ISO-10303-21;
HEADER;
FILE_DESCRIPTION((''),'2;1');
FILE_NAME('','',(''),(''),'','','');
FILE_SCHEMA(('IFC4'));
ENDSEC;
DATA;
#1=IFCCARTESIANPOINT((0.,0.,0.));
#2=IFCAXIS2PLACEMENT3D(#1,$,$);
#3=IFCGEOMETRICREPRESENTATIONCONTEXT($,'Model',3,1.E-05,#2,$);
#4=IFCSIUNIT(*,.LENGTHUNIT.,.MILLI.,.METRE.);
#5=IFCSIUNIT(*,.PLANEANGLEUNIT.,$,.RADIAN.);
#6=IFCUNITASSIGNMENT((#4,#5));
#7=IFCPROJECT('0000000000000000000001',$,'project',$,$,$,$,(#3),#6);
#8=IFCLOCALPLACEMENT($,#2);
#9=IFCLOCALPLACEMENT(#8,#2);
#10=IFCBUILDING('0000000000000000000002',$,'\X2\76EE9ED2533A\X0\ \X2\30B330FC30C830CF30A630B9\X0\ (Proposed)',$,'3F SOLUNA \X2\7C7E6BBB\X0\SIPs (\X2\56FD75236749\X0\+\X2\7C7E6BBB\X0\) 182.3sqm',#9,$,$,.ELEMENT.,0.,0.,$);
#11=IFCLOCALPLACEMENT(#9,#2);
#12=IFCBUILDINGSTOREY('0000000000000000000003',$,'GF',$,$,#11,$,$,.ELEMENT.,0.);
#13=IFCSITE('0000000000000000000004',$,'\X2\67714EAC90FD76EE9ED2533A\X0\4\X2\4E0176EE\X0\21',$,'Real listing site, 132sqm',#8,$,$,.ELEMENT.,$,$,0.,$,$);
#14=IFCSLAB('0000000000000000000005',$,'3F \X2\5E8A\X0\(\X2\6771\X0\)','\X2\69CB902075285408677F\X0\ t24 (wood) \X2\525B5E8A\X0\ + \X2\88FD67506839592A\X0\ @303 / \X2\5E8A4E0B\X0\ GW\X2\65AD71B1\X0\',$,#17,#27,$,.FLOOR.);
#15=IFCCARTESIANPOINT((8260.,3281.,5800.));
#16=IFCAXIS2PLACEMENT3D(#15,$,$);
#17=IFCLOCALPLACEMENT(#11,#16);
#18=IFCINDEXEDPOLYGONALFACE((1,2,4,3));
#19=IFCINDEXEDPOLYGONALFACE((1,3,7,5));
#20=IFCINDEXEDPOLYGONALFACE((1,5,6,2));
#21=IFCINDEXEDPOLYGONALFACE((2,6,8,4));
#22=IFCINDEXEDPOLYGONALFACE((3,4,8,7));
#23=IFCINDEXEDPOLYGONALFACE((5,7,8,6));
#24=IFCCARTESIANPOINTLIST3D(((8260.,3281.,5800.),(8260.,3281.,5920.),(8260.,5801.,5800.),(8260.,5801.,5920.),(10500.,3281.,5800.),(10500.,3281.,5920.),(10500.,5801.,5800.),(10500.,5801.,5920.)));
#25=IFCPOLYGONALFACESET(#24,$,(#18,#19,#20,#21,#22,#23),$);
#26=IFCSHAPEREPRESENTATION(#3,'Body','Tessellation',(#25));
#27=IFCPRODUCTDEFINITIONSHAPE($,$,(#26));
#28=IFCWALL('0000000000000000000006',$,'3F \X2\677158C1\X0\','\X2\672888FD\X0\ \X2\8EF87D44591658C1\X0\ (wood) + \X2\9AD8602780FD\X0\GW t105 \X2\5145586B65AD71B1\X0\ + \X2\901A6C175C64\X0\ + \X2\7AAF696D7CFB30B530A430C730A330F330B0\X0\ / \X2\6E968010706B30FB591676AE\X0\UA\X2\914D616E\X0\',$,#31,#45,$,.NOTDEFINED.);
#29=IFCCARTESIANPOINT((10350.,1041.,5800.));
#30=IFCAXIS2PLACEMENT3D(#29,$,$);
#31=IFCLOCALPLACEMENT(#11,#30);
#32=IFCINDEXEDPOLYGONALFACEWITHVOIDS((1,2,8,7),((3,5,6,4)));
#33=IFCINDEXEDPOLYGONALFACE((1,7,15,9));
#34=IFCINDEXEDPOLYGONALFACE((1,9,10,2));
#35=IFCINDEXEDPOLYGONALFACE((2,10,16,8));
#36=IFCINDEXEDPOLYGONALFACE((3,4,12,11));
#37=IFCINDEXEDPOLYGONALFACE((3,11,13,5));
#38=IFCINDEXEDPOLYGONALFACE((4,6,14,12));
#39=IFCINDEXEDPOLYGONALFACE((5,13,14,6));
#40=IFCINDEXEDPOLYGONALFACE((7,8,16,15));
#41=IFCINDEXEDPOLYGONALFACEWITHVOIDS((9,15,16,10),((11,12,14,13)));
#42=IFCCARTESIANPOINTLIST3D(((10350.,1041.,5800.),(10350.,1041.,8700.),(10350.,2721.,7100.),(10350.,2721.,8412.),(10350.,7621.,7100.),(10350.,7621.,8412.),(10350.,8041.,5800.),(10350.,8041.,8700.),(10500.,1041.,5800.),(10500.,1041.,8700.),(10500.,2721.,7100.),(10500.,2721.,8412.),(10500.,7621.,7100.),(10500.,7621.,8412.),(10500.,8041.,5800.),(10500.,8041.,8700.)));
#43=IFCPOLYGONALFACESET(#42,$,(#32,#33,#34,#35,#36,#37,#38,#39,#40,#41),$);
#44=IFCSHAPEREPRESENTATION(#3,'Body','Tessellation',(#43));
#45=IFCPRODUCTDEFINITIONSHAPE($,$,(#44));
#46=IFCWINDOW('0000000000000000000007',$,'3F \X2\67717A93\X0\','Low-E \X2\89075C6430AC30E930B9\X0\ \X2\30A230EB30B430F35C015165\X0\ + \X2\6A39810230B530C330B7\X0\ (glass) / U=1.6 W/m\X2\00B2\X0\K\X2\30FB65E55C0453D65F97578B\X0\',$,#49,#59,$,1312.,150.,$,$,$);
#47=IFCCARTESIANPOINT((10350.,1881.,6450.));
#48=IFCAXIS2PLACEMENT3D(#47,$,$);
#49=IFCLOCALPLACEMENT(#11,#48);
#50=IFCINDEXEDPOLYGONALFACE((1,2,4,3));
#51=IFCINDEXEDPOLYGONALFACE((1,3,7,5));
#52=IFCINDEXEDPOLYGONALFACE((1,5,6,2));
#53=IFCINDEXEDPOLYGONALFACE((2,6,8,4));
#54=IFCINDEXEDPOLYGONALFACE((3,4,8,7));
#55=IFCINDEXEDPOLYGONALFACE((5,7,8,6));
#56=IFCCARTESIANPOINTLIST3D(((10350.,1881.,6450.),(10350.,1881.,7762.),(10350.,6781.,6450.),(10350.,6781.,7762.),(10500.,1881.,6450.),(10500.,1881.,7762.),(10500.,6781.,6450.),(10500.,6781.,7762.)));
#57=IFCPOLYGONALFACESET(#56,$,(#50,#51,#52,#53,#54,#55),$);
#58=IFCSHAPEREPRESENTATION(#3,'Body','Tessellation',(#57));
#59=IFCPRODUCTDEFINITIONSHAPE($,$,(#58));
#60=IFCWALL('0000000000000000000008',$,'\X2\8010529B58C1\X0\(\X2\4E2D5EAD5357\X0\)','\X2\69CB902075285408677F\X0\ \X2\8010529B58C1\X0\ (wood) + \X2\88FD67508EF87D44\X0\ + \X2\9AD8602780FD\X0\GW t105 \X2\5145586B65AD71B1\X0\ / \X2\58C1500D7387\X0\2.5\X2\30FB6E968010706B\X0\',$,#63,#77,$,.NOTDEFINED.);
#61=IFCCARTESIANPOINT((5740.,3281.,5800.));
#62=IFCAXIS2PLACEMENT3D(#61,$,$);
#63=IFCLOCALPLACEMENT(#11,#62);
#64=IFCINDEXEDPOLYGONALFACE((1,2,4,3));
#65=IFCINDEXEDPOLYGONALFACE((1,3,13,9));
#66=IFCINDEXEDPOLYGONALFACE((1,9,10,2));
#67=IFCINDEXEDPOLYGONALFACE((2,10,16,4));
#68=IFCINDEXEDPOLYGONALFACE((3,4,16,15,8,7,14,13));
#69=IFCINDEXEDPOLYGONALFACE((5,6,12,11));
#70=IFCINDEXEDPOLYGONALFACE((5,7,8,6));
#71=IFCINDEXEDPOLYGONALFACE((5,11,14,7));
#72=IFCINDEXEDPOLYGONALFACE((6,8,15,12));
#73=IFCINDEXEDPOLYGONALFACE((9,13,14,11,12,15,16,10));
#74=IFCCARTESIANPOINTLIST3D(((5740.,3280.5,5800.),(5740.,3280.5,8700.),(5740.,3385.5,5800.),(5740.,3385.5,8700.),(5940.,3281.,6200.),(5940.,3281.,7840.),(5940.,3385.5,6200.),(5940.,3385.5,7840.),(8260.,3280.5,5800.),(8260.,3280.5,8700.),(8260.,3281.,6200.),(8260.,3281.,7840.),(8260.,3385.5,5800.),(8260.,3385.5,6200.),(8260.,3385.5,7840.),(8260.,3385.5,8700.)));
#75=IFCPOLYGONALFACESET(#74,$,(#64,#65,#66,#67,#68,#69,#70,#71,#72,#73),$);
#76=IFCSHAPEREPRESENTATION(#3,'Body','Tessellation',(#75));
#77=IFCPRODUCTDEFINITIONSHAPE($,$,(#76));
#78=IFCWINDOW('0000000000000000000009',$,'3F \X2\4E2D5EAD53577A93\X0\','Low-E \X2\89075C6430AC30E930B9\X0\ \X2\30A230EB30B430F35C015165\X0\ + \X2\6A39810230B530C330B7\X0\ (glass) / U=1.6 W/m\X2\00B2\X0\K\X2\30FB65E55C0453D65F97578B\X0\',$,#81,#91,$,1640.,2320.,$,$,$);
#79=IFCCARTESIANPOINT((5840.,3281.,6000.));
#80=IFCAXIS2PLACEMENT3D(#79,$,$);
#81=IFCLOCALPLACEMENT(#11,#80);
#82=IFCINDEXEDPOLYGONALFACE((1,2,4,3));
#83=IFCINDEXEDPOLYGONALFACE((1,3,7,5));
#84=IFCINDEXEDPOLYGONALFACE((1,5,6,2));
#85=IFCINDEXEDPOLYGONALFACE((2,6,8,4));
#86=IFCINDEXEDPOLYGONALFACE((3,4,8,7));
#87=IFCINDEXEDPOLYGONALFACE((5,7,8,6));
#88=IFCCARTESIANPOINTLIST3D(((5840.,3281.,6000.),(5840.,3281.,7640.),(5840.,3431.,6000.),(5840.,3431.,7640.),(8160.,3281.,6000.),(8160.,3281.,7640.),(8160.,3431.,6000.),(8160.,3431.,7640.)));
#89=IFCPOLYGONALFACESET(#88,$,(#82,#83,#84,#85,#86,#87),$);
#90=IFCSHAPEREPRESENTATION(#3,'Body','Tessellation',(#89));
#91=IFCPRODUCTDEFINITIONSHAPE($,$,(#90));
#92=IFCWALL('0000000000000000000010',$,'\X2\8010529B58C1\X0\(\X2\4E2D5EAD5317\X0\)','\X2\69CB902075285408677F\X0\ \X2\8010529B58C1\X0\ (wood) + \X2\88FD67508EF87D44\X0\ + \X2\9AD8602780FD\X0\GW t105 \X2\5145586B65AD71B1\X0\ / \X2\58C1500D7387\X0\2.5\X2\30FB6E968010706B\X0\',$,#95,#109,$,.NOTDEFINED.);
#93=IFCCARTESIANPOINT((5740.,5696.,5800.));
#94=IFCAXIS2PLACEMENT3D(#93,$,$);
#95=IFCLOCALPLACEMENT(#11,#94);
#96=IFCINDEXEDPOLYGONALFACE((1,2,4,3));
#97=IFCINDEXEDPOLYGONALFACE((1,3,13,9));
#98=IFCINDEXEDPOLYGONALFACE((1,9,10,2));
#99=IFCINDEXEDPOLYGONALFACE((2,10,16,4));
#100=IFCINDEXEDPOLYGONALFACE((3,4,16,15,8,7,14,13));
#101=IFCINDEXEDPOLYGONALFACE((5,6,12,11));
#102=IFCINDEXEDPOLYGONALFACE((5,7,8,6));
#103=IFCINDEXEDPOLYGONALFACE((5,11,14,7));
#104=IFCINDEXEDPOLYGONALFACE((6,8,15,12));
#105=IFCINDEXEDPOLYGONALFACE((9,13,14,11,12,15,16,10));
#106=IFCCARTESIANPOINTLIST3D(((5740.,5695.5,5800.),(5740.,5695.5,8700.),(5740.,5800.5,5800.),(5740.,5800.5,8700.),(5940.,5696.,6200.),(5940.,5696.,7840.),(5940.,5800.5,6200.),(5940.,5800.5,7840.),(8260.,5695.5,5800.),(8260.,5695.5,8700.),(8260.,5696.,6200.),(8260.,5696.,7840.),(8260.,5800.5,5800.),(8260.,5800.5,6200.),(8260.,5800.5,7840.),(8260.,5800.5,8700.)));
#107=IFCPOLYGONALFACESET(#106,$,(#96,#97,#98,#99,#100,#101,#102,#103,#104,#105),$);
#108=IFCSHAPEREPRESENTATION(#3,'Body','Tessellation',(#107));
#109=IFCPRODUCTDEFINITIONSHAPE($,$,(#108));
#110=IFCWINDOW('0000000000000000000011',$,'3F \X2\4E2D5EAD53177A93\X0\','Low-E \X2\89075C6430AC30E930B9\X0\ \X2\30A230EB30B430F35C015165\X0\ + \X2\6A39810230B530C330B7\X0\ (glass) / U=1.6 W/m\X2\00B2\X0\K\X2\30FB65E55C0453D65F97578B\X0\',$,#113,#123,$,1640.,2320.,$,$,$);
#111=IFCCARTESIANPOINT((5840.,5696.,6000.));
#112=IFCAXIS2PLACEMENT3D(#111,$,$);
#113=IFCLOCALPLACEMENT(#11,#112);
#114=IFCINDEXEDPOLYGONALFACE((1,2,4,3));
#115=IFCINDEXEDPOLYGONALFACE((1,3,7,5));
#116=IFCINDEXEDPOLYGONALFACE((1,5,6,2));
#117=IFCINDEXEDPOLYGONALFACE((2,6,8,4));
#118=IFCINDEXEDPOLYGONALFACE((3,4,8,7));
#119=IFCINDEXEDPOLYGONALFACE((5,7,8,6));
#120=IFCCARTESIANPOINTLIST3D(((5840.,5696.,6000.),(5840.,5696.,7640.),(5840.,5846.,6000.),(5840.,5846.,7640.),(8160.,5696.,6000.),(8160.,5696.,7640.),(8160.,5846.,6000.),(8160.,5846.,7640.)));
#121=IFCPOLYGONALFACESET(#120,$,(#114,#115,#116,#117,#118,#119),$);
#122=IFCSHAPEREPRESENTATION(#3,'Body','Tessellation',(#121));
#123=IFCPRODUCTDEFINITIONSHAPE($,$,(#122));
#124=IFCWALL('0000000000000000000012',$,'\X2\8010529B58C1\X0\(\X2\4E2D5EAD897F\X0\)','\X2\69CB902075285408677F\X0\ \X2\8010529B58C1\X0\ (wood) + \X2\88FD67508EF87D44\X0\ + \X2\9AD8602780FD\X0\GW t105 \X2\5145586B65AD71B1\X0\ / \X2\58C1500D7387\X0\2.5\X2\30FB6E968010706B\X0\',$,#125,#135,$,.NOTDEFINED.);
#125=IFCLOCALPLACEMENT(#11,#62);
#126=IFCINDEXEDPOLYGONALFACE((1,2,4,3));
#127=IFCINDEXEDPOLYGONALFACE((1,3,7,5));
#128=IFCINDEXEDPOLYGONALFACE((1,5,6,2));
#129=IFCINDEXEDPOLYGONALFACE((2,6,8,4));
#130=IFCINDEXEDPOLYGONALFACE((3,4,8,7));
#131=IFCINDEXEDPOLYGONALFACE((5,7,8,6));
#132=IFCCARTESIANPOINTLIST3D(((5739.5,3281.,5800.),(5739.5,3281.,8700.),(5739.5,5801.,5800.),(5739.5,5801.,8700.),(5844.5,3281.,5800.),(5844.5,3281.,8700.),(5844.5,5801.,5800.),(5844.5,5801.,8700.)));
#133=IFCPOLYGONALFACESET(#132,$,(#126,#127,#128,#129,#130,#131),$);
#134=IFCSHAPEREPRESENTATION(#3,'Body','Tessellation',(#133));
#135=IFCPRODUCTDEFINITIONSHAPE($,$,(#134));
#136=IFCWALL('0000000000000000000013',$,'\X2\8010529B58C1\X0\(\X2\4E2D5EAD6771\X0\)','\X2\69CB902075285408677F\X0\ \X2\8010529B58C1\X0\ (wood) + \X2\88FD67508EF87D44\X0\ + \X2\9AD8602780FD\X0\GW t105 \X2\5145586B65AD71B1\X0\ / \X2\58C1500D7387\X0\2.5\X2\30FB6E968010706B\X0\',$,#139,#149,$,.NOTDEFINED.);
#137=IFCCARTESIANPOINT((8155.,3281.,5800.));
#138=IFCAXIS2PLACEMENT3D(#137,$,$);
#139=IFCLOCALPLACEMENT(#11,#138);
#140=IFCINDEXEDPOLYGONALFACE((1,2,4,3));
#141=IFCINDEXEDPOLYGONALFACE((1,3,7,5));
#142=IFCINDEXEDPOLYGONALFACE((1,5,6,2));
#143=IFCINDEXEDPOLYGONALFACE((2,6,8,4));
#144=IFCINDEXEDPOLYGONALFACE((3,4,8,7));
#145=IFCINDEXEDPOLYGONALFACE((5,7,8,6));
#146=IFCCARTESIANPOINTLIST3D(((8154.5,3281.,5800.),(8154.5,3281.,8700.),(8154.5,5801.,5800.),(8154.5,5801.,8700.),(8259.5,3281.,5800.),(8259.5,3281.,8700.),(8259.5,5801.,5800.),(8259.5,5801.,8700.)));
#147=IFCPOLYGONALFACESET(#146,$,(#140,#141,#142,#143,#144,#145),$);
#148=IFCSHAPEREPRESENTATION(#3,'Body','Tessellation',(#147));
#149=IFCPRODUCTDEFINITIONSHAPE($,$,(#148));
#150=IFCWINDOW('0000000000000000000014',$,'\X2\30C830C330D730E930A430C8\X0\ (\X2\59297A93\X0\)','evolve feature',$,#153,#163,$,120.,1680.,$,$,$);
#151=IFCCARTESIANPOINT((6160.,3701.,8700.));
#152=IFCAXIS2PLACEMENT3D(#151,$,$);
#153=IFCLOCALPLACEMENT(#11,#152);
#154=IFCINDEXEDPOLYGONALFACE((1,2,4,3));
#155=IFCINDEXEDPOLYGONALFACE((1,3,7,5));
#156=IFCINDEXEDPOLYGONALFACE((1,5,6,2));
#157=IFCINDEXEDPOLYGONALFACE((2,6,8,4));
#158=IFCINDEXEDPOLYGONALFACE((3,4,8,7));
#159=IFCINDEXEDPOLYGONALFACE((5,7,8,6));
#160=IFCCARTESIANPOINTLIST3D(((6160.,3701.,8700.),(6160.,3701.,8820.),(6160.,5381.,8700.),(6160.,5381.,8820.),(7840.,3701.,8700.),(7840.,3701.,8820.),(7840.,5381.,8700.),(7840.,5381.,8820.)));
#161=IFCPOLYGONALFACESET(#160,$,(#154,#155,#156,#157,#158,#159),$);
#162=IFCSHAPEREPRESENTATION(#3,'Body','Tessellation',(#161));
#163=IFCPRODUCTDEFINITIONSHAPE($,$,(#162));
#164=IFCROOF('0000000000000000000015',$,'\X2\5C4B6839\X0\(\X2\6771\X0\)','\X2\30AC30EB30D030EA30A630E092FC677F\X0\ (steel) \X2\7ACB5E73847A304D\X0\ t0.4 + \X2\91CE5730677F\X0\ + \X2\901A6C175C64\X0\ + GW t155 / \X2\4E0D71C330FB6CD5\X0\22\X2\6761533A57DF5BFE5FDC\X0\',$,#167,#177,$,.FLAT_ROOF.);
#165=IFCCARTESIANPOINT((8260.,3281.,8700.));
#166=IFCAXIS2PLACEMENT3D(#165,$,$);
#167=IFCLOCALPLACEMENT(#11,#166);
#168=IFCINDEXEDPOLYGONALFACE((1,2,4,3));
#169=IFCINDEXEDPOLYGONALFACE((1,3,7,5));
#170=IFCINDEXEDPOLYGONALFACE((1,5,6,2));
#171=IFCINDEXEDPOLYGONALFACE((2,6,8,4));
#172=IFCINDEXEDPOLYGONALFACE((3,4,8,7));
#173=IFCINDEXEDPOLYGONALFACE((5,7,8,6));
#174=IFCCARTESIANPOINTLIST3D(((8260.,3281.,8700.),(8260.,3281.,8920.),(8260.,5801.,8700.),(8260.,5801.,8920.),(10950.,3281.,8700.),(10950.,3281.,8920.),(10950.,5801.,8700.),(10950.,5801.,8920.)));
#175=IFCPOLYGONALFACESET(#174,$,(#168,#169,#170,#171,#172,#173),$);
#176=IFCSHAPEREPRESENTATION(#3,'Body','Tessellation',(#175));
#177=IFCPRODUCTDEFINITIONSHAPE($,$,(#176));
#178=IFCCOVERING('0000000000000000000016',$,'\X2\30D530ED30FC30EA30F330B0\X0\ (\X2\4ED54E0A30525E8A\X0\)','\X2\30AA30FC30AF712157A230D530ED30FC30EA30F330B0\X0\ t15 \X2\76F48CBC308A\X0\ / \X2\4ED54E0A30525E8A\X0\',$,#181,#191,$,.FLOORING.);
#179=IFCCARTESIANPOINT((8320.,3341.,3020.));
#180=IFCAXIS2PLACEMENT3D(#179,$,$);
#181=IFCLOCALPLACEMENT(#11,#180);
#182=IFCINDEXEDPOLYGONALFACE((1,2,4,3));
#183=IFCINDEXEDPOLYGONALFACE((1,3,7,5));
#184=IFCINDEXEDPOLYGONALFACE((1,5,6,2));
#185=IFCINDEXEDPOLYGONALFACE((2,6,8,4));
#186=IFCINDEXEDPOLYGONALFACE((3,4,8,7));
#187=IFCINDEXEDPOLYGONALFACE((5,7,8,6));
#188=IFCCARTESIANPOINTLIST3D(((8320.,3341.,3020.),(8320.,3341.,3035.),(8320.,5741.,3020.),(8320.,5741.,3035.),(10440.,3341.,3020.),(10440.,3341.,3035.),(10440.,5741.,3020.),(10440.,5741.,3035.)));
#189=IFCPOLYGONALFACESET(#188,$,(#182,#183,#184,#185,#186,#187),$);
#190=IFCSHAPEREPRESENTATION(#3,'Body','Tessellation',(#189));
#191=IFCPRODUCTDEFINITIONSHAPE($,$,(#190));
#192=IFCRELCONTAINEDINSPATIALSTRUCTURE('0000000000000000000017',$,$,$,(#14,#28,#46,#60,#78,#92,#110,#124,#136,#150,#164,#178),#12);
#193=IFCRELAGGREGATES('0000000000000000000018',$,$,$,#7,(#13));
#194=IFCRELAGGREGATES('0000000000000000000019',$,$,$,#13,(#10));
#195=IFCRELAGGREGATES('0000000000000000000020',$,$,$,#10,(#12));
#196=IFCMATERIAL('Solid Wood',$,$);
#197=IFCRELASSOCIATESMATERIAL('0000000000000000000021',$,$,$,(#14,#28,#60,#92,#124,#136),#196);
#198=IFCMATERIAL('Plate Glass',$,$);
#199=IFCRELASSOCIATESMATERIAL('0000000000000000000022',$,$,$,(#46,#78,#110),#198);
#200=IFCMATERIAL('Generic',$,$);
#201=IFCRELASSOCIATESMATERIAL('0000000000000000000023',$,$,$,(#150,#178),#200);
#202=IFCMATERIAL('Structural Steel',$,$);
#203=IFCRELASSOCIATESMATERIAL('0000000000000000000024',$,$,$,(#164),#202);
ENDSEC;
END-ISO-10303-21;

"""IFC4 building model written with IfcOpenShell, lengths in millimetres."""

from ifc_helpers import new_model, si_unit, frame, frame_2d, origin, place, context, project, spatial, rectangle, extrude, material, element, fill, save


model = new_model("IFC4")

# Units and contexts
model_context = context("Model", 3, precision=1e-05, world=origin())
ifc_project = project(units=[si_unit("LENGTHUNIT", "METRE", prefix="MILLI"), si_unit("PLANEANGLEUNIT", "RADIAN")], contexts=[model_context])

# Site, building, storey
site_placement = place(None, origin())
site = spatial("IfcSite", under=ifc_project, at=site_placement, Name="東京都目黒区4丁目21", ObjectType="Real listing site, 132sqm", CompositionType="ELEMENT", RefElevation=0.0)
building_placement = place(site_placement, origin())
building = spatial("IfcBuilding", under=site, at=building_placement, Name="目黒区 コートハウス (Proposed)", ObjectType="3F SOLUNA 籾殻SIPs (国産杉+籾殻) 182.3sqm", CompositionType="ELEMENT", ElevationOfRefHeight=0.0, ElevationOfTerrain=0.0)
storey_placement = place(building_placement, origin())
storey = spatial("IfcBuildingStorey", under=building, at=storey_placement, Name="GF", CompositionType="ELEMENT", Elevation=0.0)

# Slab
ifc_material_1 = material(Name="Solid Wood")
slab_placement = place(storey_placement, frame((8260.0, 3281.0, 5800.0)))
element("IfcSlab", 1, at=slab_placement, inside=storey, material=ifc_material_1, Name="3F 床(東)", Description="構造用合板 t24 (wood) 剛床 + 製材根太 @303 / 床下 GW断熱", PredefinedType="FLOOR", context=model_context, shape_type="SweptSolid", body=[
    extrude(rectangle(XDim=2240.0, YDim=2520.0, at=frame_2d((1120.0, 1260.0))), frame((8260.0, 3281.0, 5800.0)), (0.0, 0.0, 1.0), 120.0),
])

# Walls, openings, windows
wall_1_placement = place(storey_placement, frame((10350.0, 1041.0, 5800.0)))
wall_1 = element("IfcWall", 2, at=wall_1_placement, inside=storey, material=ifc_material_1, Name="3F 東壁", Description="木製 軸組外壁 (wood) + 高性能GW t105 充填断熱 + 通気層 + 窯業系サイディング / 準耐火・外皮UA配慮", PredefinedType="NOTDEFINED", context=model_context, shape_type="SweptSolid", body=[
    extrude(rectangle(XDim=150.0, YDim=7000.0, at=frame_2d((75.0, 3500.0))), frame((10350.0, 1041.0, 5800.0)), (0.0, 0.0, 1.0), 2900.0),
])
opening_1_placement = place(storey_placement, frame((10350.0, 1881.0, 6450.0)))
opening_1 = element("IfcOpeningElement", 3, at=opening_1_placement, cuts=wall_1, PredefinedType="NOTDEFINED", context=model_context, shape_type="SweptSolid", body=[
    extrude(rectangle(XDim=150.0, YDim=4900.0, at=frame_2d((75.0, 2450.0))), frame((10350.0, 1881.0, 6450.0)), (0.0, 0.0, 1.0), 1312.0),
])
ifc_material_2 = material(Name="Plate Glass")
window_1_placement = place(storey_placement, frame((10350.0, 1881.0, 6450.0)))
window_1 = element("IfcWindow", 4, at=window_1_placement, inside=storey, material=ifc_material_2, Name="3F 東窓", Description="Low-E 複層ガラス アルゴン封入 + 樹脂サッシ (glass) / U=1.6 W/m²K・日射取得型", OverallHeight=1312.0, OverallWidth=150.0, context=model_context, shape_type="SweptSolid", body=[
    extrude(rectangle(XDim=150.0, YDim=4900.0, at=frame_2d((75.0, 2450.0))), frame((10350.0, 1881.0, 6450.0)), (0.0, 0.0, 1.0), 1312.0),
])
fill(opening_1, window_1)
wall_2_placement = place(storey_placement, frame((5740.0, 3281.0, 5800.0)))
wall_2 = element("IfcWall", 5, at=wall_2_placement, inside=storey, material=ifc_material_1, Name="耐力壁(中庭南)", Description="構造用合板 耐力壁 (wood) + 製材軸組 + 高性能GW t105 充填断熱 / 壁倍率2.5・準耐火", PredefinedType="NOTDEFINED", context=model_context, shape_type="SweptSolid", body=[
    extrude(rectangle(XDim=2520.0, YDim=105.0, at=frame_2d((1260.0, 52.0))), frame((5740.0, 3281.0, 5800.0)), (0.0, 0.0, 1.0), 2900.0),
])
opening_2_placement = place(storey_placement, frame((5840.0, 3281.0, 6000.0)))
opening_2 = element("IfcOpeningElement", 6, at=opening_2_placement, cuts=wall_2, PredefinedType="NOTDEFINED", context=model_context, shape_type="SweptSolid", body=[
    extrude(rectangle(XDim=2320.0, YDim=150.0, at=frame_2d((1160.0, 75.0))), frame((5840.0, 3281.0, 6000.0)), (0.0, 0.0, 1.0), 1640.0),
])
window_2_placement = place(storey_placement, frame((5840.0, 3281.0, 6000.0)))
window_2 = element("IfcWindow", 7, at=window_2_placement, inside=storey, material=ifc_material_2, Name="3F 中庭南窓", Description="Low-E 複層ガラス アルゴン封入 + 樹脂サッシ (glass) / U=1.6 W/m²K・日射取得型", OverallHeight=1640.0, OverallWidth=2320.0, context=model_context, shape_type="SweptSolid", body=[
    extrude(rectangle(XDim=2320.0, YDim=150.0, at=frame_2d((1160.0, 75.0))), frame((5840.0, 3281.0, 6000.0)), (0.0, 0.0, 1.0), 1640.0),
])
fill(opening_2, window_2)
wall_3_placement = place(storey_placement, frame((5740.0, 5696.0, 5800.0)))
wall_3 = element("IfcWall", 8, at=wall_3_placement, inside=storey, material=ifc_material_1, Name="耐力壁(中庭北)", Description="構造用合板 耐力壁 (wood) + 製材軸組 + 高性能GW t105 充填断熱 / 壁倍率2.5・準耐火", PredefinedType="NOTDEFINED", context=model_context, shape_type="SweptSolid", body=[
    extrude(rectangle(XDim=2520.0, YDim=105.0, at=frame_2d((1260.0, 52.0))), frame((5740.0, 5696.0, 5800.0)), (0.0, 0.0, 1.0), 2900.0),
])
opening_3_placement = place(storey_placement, frame((5840.0, 5696.0, 6000.0)))
opening_3 = element("IfcOpeningElement", 9, at=opening_3_placement, cuts=wall_3, PredefinedType="NOTDEFINED", context=model_context, shape_type="SweptSolid", body=[
    extrude(rectangle(XDim=2320.0, YDim=150.0, at=frame_2d((1160.0, 75.0))), frame((5840.0, 5696.0, 6000.0)), (0.0, 0.0, 1.0), 1640.0),
])
window_3_placement = place(storey_placement, frame((5840.0, 5696.0, 6000.0)))
window_3 = element("IfcWindow", 10, at=window_3_placement, inside=storey, material=ifc_material_2, Name="3F 中庭北窓", Description="Low-E 複層ガラス アルゴン封入 + 樹脂サッシ (glass) / U=1.6 W/m²K・日射取得型", OverallHeight=1640.0, OverallWidth=2320.0, context=model_context, shape_type="SweptSolid", body=[
    extrude(rectangle(XDim=2320.0, YDim=150.0, at=frame_2d((1160.0, 75.0))), frame((5840.0, 5696.0, 6000.0)), (0.0, 0.0, 1.0), 1640.0),
])
fill(opening_3, window_3)

# Walls
wall_4_placement = place(storey_placement, frame((5740.0, 3281.0, 5800.0)))
element("IfcWall", 11, at=wall_4_placement, inside=storey, material=ifc_material_1, Name="耐力壁(中庭西)", Description="構造用合板 耐力壁 (wood) + 製材軸組 + 高性能GW t105 充填断熱 / 壁倍率2.5・準耐火", PredefinedType="NOTDEFINED", context=model_context, shape_type="SweptSolid", body=[
    extrude(rectangle(XDim=105.0, YDim=2520.0, at=frame_2d((52.0, 1260.0))), frame((5740.0, 3281.0, 5800.0)), (0.0, 0.0, 1.0), 2900.0),
])
wall_5_placement = place(storey_placement, frame((8155.0, 3281.0, 5800.0)))
element("IfcWall", 12, at=wall_5_placement, inside=storey, material=ifc_material_1, Name="耐力壁(中庭東)", Description="構造用合板 耐力壁 (wood) + 製材軸組 + 高性能GW t105 充填断熱 / 壁倍率2.5・準耐火", PredefinedType="NOTDEFINED", context=model_context, shape_type="SweptSolid", body=[
    extrude(rectangle(XDim=105.0, YDim=2520.0, at=frame_2d((52.0, 1260.0))), frame((8155.0, 3281.0, 5800.0)), (0.0, 0.0, 1.0), 2900.0),
])

# Window
ifc_material_3 = material(Name="Generic")
window_4_placement = place(storey_placement, frame((6160.0, 3701.0, 8700.0)))
element("IfcWindow", 13, at=window_4_placement, inside=storey, material=ifc_material_3, Name="トップライト (天窓)", Description="evolve feature", OverallHeight=120.0, OverallWidth=1680.0, context=model_context, shape_type="SweptSolid", body=[
    extrude(rectangle(XDim=1680.0, YDim=1680.0, at=frame_2d((840.0, 840.0))), frame((6160.0, 3701.0, 8700.0)), (0.0, 0.0, 1.0), 120.0),
])

# Roof
ifc_material_4 = material(Name="Structural Steel")
for number, where, name in (
    (14, (8260.0, 3281.0, 8700.0), "屋根(東)"),
):
    element("IfcRoof", number, at=place(storey_placement, frame(where)), inside=storey, material=ifc_material_4, Name=name, Description="ガルバリウム鋼板 (steel) 立平葺き t0.4 + 野地板 + 通気層 + GW t155 / 不燃・法22条区域対応", PredefinedType="FLAT_ROOF", context=model_context, shape_type="SweptSolid", body=[
        extrude(rectangle(XDim=2690.0, YDim=2520.0, at=frame_2d((1345.0, 1260.0))), frame((8260.0, 3281.0, 8700.0)), (0.0, 0.0, 1.0), 220.0),
    ])

# Covering
covering_1_placement = place(storey_placement, frame((8320.0, 3341.0, 3020.0)))
element("IfcCovering", 15, at=covering_1_placement, inside=storey, material=ifc_material_3, Name="フローリング (仕上げ床)", Description="オーク無垢フローリング t15 直貼り / 仕上げ床", PredefinedType="FLOORING", context=model_context, shape_type="SweptSolid", body=[
    extrude(rectangle(XDim=2120.0, YDim=2400.0, at=frame_2d((1060.0, 1200.0))), frame((8320.0, 3341.0, 3020.0)), (0.0, 0.0, 1.0), 15.0),
])

save(model, "model.ifc")
